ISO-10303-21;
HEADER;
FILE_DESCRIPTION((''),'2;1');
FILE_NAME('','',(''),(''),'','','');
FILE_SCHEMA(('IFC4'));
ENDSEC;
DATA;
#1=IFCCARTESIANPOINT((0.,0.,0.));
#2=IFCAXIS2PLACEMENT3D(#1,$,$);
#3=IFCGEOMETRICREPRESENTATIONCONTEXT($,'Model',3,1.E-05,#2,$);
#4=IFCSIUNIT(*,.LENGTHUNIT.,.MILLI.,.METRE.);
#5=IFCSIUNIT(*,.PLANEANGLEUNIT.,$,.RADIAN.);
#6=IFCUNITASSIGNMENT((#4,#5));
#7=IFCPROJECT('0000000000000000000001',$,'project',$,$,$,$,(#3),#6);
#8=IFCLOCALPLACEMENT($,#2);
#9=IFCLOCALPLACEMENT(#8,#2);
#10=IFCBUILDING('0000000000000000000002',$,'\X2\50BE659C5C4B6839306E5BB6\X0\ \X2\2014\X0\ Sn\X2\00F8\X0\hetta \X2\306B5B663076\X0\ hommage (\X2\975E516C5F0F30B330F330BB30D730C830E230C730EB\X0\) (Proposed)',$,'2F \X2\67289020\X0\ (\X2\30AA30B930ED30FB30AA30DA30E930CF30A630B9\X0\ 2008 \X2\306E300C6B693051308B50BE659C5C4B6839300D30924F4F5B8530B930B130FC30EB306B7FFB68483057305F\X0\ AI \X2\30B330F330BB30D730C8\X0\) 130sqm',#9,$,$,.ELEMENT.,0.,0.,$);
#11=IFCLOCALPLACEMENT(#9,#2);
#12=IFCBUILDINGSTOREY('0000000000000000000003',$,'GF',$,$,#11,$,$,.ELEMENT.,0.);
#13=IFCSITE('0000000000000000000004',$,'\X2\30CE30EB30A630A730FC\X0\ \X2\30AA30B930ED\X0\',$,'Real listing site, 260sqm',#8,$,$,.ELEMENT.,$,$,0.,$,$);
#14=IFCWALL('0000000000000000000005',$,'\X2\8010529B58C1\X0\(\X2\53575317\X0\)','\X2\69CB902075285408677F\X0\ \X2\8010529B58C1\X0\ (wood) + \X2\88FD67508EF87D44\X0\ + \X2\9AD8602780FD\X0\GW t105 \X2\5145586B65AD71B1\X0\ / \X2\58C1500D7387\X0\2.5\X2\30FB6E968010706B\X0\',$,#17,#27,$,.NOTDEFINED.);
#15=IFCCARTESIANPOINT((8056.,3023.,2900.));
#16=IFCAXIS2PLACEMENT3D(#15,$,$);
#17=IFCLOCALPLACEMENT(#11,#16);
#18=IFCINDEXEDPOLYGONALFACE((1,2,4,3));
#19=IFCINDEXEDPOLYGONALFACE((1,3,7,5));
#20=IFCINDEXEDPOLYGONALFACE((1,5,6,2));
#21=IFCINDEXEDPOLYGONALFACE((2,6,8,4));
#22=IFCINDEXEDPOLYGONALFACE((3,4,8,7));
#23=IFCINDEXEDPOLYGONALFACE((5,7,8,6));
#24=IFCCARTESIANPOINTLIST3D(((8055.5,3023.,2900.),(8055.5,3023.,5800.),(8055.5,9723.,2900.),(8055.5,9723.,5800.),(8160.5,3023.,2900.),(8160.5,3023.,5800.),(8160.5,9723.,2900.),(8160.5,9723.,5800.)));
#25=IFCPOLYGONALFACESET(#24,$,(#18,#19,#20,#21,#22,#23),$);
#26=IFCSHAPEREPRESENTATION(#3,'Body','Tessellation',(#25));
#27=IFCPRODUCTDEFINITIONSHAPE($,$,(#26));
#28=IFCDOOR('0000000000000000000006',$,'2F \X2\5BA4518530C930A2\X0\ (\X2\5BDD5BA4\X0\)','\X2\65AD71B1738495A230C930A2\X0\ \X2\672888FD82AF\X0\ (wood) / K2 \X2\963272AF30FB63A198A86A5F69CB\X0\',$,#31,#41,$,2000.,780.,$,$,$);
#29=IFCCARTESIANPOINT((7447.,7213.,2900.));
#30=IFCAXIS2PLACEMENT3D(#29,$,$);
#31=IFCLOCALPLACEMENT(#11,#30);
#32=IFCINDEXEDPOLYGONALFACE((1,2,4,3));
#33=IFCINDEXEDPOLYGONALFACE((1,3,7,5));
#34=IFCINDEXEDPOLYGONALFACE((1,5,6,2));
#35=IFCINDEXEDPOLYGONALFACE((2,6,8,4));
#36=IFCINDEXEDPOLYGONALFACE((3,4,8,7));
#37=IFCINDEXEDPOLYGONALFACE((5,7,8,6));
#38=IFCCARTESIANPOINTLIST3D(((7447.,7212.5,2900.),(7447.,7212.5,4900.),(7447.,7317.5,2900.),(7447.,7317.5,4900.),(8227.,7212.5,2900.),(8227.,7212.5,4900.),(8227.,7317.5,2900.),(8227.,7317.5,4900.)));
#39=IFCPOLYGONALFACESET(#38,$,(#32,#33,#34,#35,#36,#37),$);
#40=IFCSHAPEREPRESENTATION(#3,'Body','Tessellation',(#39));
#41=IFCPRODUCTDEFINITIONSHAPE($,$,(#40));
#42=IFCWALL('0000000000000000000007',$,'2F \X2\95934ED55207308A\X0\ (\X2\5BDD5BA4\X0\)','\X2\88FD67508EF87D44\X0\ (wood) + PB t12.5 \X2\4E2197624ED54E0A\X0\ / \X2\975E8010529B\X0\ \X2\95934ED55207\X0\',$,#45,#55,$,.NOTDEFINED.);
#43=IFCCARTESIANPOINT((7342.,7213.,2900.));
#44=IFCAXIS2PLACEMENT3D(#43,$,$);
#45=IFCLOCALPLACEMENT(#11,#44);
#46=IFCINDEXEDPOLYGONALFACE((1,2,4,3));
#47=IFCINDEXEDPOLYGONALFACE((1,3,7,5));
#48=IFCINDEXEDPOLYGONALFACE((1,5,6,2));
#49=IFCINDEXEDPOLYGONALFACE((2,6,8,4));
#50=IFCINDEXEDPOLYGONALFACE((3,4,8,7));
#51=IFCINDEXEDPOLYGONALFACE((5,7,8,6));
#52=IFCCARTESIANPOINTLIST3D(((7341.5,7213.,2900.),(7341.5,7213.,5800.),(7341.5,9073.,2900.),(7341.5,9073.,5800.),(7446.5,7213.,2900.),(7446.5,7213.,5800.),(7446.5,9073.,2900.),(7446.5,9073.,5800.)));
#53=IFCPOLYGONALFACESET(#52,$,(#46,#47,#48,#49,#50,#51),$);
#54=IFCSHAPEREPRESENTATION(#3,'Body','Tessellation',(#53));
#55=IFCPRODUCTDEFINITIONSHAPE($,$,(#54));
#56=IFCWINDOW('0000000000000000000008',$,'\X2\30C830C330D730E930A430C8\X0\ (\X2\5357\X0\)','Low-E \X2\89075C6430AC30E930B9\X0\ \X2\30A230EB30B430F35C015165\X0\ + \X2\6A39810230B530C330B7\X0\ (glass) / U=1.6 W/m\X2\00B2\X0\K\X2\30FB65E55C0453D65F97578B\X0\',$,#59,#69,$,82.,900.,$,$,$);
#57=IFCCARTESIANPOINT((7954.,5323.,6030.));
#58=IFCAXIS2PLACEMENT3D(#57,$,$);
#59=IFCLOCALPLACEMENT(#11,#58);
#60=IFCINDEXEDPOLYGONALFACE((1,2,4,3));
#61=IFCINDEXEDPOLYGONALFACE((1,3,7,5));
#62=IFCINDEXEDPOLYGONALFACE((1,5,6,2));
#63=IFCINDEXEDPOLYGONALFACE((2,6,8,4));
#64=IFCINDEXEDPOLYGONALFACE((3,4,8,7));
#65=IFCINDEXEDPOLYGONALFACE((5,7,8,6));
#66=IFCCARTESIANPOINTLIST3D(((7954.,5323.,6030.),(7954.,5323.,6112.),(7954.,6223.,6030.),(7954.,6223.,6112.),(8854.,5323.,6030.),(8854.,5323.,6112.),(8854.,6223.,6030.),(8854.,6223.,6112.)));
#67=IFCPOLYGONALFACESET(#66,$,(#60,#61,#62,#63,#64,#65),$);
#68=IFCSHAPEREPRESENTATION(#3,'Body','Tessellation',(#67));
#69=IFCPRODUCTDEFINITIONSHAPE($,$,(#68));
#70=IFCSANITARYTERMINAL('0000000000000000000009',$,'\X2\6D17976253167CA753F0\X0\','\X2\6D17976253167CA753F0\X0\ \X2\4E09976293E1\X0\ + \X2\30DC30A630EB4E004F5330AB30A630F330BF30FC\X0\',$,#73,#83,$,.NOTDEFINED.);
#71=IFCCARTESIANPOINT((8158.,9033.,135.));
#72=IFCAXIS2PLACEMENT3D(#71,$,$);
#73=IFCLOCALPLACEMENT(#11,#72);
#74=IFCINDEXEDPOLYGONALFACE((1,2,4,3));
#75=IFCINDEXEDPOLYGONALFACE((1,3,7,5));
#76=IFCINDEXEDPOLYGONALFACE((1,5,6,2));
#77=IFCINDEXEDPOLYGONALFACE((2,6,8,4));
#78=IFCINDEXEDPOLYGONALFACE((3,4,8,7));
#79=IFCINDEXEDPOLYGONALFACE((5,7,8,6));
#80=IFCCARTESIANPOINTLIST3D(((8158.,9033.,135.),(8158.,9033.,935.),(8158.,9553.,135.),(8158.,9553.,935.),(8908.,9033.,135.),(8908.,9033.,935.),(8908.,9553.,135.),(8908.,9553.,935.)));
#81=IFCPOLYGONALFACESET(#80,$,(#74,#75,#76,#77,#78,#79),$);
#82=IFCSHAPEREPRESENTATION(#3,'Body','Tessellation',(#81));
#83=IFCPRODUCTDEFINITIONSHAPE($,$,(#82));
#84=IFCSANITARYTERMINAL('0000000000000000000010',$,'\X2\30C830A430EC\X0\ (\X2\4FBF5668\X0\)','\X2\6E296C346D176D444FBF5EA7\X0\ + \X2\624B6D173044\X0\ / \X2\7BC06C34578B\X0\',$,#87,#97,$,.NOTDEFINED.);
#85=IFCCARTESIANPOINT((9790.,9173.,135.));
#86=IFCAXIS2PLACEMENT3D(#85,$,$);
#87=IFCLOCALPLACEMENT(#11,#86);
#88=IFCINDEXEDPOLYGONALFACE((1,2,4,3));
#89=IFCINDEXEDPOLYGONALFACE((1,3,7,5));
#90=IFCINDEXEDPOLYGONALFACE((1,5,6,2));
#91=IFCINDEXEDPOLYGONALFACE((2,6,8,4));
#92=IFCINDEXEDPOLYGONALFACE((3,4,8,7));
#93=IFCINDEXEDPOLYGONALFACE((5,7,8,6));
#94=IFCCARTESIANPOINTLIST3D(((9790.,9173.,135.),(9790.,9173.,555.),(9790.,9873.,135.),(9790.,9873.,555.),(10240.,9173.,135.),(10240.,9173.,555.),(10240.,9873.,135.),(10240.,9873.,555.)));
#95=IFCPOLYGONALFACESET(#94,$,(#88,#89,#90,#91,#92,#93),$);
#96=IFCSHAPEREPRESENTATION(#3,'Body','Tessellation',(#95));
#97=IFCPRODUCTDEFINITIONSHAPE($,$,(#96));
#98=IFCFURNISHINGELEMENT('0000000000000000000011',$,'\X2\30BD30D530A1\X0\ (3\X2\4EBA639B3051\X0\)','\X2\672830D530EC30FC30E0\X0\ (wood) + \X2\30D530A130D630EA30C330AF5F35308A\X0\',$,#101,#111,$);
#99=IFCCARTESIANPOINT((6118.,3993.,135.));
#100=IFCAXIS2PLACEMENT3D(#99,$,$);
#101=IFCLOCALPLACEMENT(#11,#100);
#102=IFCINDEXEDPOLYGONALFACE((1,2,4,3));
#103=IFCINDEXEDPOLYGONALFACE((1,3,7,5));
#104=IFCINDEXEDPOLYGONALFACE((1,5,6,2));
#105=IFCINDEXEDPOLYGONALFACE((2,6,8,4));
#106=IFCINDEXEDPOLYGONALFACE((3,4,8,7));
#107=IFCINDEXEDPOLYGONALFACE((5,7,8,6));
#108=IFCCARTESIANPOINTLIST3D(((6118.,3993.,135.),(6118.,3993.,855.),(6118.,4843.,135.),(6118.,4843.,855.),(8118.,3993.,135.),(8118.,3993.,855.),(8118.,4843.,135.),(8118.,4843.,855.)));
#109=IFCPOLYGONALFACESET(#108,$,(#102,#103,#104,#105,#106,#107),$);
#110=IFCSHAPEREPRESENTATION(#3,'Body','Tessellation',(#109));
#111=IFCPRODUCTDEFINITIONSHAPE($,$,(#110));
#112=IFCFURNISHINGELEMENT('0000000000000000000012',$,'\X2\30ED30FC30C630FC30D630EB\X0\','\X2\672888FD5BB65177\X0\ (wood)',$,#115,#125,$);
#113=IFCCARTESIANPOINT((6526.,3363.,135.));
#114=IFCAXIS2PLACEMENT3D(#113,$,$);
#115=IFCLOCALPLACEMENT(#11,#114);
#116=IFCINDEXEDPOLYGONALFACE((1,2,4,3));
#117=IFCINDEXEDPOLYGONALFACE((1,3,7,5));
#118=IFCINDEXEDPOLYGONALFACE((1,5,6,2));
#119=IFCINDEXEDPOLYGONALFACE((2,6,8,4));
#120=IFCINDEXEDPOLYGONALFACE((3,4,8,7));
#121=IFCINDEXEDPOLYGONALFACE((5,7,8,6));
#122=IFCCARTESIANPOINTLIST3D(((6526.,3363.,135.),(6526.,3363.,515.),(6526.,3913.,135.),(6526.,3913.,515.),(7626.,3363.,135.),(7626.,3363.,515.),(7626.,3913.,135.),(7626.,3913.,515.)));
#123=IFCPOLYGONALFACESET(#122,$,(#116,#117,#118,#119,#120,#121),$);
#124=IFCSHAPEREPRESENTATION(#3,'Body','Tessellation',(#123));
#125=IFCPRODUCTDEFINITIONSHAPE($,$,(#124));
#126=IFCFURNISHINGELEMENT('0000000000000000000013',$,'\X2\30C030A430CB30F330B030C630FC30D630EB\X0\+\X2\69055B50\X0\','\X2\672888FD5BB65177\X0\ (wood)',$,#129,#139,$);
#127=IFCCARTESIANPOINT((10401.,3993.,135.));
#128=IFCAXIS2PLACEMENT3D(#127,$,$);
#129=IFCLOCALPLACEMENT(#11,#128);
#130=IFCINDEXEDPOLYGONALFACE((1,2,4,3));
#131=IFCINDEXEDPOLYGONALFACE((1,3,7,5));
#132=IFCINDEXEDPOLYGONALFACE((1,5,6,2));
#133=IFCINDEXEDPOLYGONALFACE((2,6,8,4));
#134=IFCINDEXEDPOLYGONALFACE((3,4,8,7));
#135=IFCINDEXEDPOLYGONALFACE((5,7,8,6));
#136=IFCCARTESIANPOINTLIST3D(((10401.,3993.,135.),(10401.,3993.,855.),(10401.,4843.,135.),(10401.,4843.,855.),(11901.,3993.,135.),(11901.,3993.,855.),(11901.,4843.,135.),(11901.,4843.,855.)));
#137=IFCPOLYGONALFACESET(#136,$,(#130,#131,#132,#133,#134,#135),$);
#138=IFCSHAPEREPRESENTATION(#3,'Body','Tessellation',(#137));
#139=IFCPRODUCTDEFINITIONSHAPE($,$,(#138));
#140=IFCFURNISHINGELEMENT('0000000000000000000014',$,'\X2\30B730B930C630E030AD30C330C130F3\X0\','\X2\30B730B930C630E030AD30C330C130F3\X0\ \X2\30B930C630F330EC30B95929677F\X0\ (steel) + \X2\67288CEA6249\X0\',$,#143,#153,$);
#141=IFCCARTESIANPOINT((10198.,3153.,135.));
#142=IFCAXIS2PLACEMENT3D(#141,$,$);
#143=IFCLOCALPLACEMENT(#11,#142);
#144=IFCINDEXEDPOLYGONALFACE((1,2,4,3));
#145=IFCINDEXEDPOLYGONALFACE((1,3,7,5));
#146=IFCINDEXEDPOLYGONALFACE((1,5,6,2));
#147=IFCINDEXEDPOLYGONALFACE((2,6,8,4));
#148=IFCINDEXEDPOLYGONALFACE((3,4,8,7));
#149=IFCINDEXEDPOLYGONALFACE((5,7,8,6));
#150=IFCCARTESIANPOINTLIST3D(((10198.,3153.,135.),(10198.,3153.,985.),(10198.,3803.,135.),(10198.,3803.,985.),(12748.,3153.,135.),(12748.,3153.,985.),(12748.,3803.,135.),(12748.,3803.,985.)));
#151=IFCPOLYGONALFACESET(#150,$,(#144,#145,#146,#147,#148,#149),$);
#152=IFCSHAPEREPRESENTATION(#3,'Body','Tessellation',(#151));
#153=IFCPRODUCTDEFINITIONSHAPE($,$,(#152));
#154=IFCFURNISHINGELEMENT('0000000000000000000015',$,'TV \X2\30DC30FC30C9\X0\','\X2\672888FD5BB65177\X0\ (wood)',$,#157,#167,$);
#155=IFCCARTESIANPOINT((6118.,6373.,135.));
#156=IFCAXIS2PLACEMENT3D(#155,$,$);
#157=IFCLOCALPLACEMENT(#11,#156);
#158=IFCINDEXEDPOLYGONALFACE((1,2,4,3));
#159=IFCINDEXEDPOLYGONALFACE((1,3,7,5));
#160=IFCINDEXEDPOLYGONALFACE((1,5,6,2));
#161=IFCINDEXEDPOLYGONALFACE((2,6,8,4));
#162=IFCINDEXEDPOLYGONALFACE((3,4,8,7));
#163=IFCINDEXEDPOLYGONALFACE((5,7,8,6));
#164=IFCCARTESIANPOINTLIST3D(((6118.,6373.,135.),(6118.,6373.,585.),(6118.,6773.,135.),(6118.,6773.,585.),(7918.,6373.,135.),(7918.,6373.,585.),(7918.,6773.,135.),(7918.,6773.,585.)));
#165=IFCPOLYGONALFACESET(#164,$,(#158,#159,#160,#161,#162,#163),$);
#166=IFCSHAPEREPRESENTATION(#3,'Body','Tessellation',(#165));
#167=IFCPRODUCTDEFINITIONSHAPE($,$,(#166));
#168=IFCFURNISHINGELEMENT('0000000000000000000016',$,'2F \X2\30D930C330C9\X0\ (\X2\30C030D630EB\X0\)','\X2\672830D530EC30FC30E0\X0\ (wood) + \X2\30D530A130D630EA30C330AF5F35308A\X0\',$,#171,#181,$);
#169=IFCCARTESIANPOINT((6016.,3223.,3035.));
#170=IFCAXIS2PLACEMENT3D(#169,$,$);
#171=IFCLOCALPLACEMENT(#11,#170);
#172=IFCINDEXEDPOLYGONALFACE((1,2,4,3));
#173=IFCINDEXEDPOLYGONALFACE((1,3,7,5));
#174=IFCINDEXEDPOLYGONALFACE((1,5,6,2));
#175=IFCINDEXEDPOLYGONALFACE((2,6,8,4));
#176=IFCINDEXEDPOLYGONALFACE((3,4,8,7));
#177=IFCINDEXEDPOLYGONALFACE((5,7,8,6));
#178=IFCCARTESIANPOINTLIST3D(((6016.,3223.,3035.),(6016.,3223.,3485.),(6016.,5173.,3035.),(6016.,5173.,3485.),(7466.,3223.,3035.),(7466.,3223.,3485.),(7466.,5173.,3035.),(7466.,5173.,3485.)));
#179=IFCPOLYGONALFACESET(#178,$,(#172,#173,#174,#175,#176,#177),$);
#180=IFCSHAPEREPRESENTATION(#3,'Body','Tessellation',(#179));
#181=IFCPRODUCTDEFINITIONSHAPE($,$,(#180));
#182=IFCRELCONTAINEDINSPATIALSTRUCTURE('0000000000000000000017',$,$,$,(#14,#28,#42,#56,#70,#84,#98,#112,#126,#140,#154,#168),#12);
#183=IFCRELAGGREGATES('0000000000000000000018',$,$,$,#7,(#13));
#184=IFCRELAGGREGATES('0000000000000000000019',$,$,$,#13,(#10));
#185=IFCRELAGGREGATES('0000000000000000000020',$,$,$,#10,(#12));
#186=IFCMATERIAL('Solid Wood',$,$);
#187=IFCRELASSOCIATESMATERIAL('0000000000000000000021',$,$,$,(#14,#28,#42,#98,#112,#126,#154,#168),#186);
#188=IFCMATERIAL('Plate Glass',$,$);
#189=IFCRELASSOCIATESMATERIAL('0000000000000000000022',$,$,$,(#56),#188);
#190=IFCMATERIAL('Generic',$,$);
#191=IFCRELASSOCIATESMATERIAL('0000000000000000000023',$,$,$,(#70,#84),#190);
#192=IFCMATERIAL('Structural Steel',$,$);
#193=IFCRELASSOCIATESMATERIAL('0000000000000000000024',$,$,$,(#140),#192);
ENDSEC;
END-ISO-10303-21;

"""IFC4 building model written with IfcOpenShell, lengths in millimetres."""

from ifc_helpers import new_model, si_unit, frame, frame_2d, origin, place, context, project, spatial, rectangle, extrude, material, element, fill, save


model = new_model("IFC4")

# Units and contexts
model_context = context("Model", 3, precision=1e-05, world=origin())
ifc_project = project(units=[si_unit("LENGTHUNIT", "METRE", prefix="MILLI"), si_unit("PLANEANGLEUNIT", "RADIAN")], contexts=[model_context])

# Site, building, storey
site_placement = place(None, origin())
site = spatial("IfcSite", under=ifc_project, at=site_placement, Name="ノルウェー オスロ", ObjectType="Real listing site, 260sqm", CompositionType="ELEMENT", RefElevation=0.0)
building_placement = place(site_placement, origin())
building = spatial("IfcBuilding", under=site, at=building_placement, Name="傾斜屋根の家 — Snøhetta に学ぶ hommage (非公式コンセプトモデル) (Proposed)", ObjectType="2F 木造 (オスロ・オペラハウス 2008 の「歩ける傾斜屋根」を住宅スケールに翻案した AI コンセプト) 130sqm", CompositionType="ELEMENT", ElevationOfRefHeight=0.0, ElevationOfTerrain=0.0)
storey_placement = place(building_placement, origin())
storey = spatial("IfcBuildingStorey", under=building, at=storey_placement, Name="GF", CompositionType="ELEMENT", Elevation=0.0)

# Shared definitions
ifc_material_1 = material(Name="Solid Wood")

# Wall, opening, door
wall_1_placement = place(storey_placement, frame((8056.0, 3023.0, 2900.0)))
wall_1 = element("IfcWall", 1, at=wall_1_placement, inside=storey, material=ifc_material_1, Name="耐力壁(南北)", Description="構造用合板 耐力壁 (wood) + 製材軸組 + 高性能GW t105 充填断熱 / 壁倍率2.5・準耐火", PredefinedType="NOTDEFINED", context=model_context, shape_type="SweptSolid", body=[
    extrude(rectangle(XDim=105.0, YDim=6700.0, at=frame_2d((52.0, 3350.0))), frame((8056.0, 3023.0, 2900.0)), (0.0, 0.0, 1.0), 2900.0),
])
opening_1_placement = place(storey_placement, frame((7447.0, 7213.0, 2900.0)))
opening_1 = element("IfcOpeningElement", 2, at=opening_1_placement, cuts=wall_1, PredefinedType="NOTDEFINED", context=model_context, shape_type="SweptSolid", body=[
    extrude(rectangle(XDim=780.0, YDim=105.0, at=frame_2d((390.0, 52.0))), frame((7447.0, 7213.0, 2900.0)), (0.0, 0.0, 1.0), 2000.0),
])
door_1_placement = place(storey_placement, frame((7447.0, 7213.0, 2900.0)))
door_1 = element("IfcDoor", 3, at=door_1_placement, inside=storey, material=ifc_material_1, Name="2F 室内ドア (寝室)", Description="断熱玄関ドア 木製芯 (wood) / K2 防犯・採風機構", OverallHeight=2000.0, OverallWidth=780.0, context=model_context, shape_type="SweptSolid", body=[
    extrude(rectangle(XDim=780.0, YDim=105.0, at=frame_2d((390.0, 52.0))), frame((7447.0, 7213.0, 2900.0)), (0.0, 0.0, 1.0), 2000.0),
])
fill(opening_1, door_1)

# Wall
wall_2_placement = place(storey_placement, frame((7342.0, 7213.0, 2900.0)))
element("IfcWall", 4, at=wall_2_placement, inside=storey, material=ifc_material_1, Name="2F 間仕切り (寝室)", Description="製材軸組 (wood) + PB t12.5 両面仕上 / 非耐力 間仕切", PredefinedType="NOTDEFINED", context=model_context, shape_type="SweptSolid", body=[
    extrude(rectangle(XDim=105.0, YDim=1860.0, at=frame_2d((52.0, 930.0))), frame((7342.0, 7213.0, 2900.0)), (0.0, 0.0, 1.0), 2900.0),
])

# Window
ifc_material_2 = material(Name="Plate Glass")
window_placement = place(storey_placement, frame((7954.0, 5323.0, 6030.0)))
element("IfcWindow", 5, at=window_placement, inside=storey, material=ifc_material_2, Name="トップライト (南)", Description="Low-E 複層ガラス アルゴン封入 + 樹脂サッシ (glass) / U=1.6 W/m²K・日射取得型", OverallHeight=82.0, OverallWidth=900.0, context=model_context, shape_type="SweptSolid", body=[
    extrude(rectangle(XDim=900.0, YDim=900.0, at=frame_2d((450.0, 450.0))), frame((7954.0, 5323.0, 6030.0)), (0.0, 0.0, 1.0), 82.0),
])

# Sanitary terminals
ifc_material_3 = material(Name="Generic")
sanitary_terminal_1_placement = place(storey_placement, frame((8158.0, 9033.0, 135.0)))
element("IfcSanitaryTerminal", 6, at=sanitary_terminal_1_placement, inside=storey, material=ifc_material_3, Name="洗面化粧台", Description="洗面化粧台 三面鏡 + ボウル一体カウンター", PredefinedType="NOTDEFINED", context=model_context, shape_type="SweptSolid", body=[
    extrude(rectangle(XDim=750.0, YDim=520.0, at=frame_2d((375.0, 260.0))), frame((8158.0, 9033.0, 135.0)), (0.0, 0.0, 1.0), 800.0),
])
sanitary_terminal_2_placement = place(storey_placement, frame((9790.0, 9173.0, 135.0)))
element("IfcSanitaryTerminal", 7, at=sanitary_terminal_2_placement, inside=storey, material=ifc_material_3, Name="トイレ (便器)", Description="温水洗浄便座 + 手洗い / 節水型", PredefinedType="NOTDEFINED", context=model_context, shape_type="SweptSolid", body=[
    extrude(rectangle(XDim=450.0, YDim=700.0, at=frame_2d((225.0, 350.0))), frame((9790.0, 9173.0, 135.0)), (0.0, 0.0, 1.0), 420.0),
])

# Furnishing elements
furnishing_1_placement = place(storey_placement, frame((6118.0, 3993.0, 135.0)))
element("IfcFurnishingElement", 8, at=furnishing_1_placement, inside=storey, material=ifc_material_1, Name="ソファ (3人掛け)", Description="木フレーム (wood) + ファブリック張り", context=model_context, shape_type="SweptSolid", body=[
    extrude(rectangle(XDim=2000.0, YDim=850.0, at=frame_2d((1000.0, 425.0))), frame((6118.0, 3993.0, 135.0)), (0.0, 0.0, 1.0), 720.0),
])
furnishing_2_placement = place(storey_placement, frame((6526.0, 3363.0, 135.0)))
element("IfcFurnishingElement", 9, at=furnishing_2_placement, inside=storey, material=ifc_material_1, Name="ローテーブル", Description="木製家具 (wood)", context=model_context, shape_type="SweptSolid", body=[
    extrude(rectangle(XDim=1100.0, YDim=550.0, at=frame_2d((550.0, 275.0))), frame((6526.0, 3363.0, 135.0)), (0.0, 0.0, 1.0), 380.0),
])
furnishing_3_placement = place(storey_placement, frame((10401.0, 3993.0, 135.0)))
element("IfcFurnishingElement", 10, at=furnishing_3_placement, inside=storey, material=ifc_material_1, Name="ダイニングテーブル+椅子", Description="木製家具 (wood)", context=model_context, shape_type="SweptSolid", body=[
    extrude(rectangle(XDim=1500.0, YDim=850.0, at=frame_2d((750.0, 425.0))), frame((10401.0, 3993.0, 135.0)), (0.0, 0.0, 1.0), 720.0),
])
ifc_material_4 = material(Name="Structural Steel")
furnishing_4_placement = place(storey_placement, frame((10198.0, 3153.0, 135.0)))
element("IfcFurnishingElement", 11, at=furnishing_4_placement, inside=storey, material=ifc_material_4, Name="システムキッチン", Description="システムキッチン ステンレス天板 (steel) + 木質扉", context=model_context, shape_type="SweptSolid", body=[
    extrude(rectangle(XDim=2550.0, YDim=650.0, at=frame_2d((1275.0, 325.0))), frame((10198.0, 3153.0, 135.0)), (0.0, 0.0, 1.0), 850.0),
])
furnishing_5_placement = place(storey_placement, frame((6118.0, 6373.0, 135.0)))
element("IfcFurnishingElement", 12, at=furnishing_5_placement, inside=storey, material=ifc_material_1, Name="TV ボード", Description="木製家具 (wood)", context=model_context, shape_type="SweptSolid", body=[
    extrude(rectangle(XDim=1800.0, YDim=400.0, at=frame_2d((900.0, 200.0))), frame((6118.0, 6373.0, 135.0)), (0.0, 0.0, 1.0), 450.0),
])
furnishing_6_placement = place(storey_placement, frame((6016.0, 3223.0, 3035.0)))
element("IfcFurnishingElement", 13, at=furnishing_6_placement, inside=storey, material=ifc_material_1, Name="2F ベッド (ダブル)", Description="木フレーム (wood) + ファブリック張り", context=model_context, shape_type="SweptSolid", body=[
    extrude(rectangle(XDim=1450.0, YDim=1950.0, at=frame_2d((725.0, 975.0))), frame((6016.0, 3223.0, 3035.0)), (0.0, 0.0, 1.0), 450.0),
])

save(model, "model.ifc")
